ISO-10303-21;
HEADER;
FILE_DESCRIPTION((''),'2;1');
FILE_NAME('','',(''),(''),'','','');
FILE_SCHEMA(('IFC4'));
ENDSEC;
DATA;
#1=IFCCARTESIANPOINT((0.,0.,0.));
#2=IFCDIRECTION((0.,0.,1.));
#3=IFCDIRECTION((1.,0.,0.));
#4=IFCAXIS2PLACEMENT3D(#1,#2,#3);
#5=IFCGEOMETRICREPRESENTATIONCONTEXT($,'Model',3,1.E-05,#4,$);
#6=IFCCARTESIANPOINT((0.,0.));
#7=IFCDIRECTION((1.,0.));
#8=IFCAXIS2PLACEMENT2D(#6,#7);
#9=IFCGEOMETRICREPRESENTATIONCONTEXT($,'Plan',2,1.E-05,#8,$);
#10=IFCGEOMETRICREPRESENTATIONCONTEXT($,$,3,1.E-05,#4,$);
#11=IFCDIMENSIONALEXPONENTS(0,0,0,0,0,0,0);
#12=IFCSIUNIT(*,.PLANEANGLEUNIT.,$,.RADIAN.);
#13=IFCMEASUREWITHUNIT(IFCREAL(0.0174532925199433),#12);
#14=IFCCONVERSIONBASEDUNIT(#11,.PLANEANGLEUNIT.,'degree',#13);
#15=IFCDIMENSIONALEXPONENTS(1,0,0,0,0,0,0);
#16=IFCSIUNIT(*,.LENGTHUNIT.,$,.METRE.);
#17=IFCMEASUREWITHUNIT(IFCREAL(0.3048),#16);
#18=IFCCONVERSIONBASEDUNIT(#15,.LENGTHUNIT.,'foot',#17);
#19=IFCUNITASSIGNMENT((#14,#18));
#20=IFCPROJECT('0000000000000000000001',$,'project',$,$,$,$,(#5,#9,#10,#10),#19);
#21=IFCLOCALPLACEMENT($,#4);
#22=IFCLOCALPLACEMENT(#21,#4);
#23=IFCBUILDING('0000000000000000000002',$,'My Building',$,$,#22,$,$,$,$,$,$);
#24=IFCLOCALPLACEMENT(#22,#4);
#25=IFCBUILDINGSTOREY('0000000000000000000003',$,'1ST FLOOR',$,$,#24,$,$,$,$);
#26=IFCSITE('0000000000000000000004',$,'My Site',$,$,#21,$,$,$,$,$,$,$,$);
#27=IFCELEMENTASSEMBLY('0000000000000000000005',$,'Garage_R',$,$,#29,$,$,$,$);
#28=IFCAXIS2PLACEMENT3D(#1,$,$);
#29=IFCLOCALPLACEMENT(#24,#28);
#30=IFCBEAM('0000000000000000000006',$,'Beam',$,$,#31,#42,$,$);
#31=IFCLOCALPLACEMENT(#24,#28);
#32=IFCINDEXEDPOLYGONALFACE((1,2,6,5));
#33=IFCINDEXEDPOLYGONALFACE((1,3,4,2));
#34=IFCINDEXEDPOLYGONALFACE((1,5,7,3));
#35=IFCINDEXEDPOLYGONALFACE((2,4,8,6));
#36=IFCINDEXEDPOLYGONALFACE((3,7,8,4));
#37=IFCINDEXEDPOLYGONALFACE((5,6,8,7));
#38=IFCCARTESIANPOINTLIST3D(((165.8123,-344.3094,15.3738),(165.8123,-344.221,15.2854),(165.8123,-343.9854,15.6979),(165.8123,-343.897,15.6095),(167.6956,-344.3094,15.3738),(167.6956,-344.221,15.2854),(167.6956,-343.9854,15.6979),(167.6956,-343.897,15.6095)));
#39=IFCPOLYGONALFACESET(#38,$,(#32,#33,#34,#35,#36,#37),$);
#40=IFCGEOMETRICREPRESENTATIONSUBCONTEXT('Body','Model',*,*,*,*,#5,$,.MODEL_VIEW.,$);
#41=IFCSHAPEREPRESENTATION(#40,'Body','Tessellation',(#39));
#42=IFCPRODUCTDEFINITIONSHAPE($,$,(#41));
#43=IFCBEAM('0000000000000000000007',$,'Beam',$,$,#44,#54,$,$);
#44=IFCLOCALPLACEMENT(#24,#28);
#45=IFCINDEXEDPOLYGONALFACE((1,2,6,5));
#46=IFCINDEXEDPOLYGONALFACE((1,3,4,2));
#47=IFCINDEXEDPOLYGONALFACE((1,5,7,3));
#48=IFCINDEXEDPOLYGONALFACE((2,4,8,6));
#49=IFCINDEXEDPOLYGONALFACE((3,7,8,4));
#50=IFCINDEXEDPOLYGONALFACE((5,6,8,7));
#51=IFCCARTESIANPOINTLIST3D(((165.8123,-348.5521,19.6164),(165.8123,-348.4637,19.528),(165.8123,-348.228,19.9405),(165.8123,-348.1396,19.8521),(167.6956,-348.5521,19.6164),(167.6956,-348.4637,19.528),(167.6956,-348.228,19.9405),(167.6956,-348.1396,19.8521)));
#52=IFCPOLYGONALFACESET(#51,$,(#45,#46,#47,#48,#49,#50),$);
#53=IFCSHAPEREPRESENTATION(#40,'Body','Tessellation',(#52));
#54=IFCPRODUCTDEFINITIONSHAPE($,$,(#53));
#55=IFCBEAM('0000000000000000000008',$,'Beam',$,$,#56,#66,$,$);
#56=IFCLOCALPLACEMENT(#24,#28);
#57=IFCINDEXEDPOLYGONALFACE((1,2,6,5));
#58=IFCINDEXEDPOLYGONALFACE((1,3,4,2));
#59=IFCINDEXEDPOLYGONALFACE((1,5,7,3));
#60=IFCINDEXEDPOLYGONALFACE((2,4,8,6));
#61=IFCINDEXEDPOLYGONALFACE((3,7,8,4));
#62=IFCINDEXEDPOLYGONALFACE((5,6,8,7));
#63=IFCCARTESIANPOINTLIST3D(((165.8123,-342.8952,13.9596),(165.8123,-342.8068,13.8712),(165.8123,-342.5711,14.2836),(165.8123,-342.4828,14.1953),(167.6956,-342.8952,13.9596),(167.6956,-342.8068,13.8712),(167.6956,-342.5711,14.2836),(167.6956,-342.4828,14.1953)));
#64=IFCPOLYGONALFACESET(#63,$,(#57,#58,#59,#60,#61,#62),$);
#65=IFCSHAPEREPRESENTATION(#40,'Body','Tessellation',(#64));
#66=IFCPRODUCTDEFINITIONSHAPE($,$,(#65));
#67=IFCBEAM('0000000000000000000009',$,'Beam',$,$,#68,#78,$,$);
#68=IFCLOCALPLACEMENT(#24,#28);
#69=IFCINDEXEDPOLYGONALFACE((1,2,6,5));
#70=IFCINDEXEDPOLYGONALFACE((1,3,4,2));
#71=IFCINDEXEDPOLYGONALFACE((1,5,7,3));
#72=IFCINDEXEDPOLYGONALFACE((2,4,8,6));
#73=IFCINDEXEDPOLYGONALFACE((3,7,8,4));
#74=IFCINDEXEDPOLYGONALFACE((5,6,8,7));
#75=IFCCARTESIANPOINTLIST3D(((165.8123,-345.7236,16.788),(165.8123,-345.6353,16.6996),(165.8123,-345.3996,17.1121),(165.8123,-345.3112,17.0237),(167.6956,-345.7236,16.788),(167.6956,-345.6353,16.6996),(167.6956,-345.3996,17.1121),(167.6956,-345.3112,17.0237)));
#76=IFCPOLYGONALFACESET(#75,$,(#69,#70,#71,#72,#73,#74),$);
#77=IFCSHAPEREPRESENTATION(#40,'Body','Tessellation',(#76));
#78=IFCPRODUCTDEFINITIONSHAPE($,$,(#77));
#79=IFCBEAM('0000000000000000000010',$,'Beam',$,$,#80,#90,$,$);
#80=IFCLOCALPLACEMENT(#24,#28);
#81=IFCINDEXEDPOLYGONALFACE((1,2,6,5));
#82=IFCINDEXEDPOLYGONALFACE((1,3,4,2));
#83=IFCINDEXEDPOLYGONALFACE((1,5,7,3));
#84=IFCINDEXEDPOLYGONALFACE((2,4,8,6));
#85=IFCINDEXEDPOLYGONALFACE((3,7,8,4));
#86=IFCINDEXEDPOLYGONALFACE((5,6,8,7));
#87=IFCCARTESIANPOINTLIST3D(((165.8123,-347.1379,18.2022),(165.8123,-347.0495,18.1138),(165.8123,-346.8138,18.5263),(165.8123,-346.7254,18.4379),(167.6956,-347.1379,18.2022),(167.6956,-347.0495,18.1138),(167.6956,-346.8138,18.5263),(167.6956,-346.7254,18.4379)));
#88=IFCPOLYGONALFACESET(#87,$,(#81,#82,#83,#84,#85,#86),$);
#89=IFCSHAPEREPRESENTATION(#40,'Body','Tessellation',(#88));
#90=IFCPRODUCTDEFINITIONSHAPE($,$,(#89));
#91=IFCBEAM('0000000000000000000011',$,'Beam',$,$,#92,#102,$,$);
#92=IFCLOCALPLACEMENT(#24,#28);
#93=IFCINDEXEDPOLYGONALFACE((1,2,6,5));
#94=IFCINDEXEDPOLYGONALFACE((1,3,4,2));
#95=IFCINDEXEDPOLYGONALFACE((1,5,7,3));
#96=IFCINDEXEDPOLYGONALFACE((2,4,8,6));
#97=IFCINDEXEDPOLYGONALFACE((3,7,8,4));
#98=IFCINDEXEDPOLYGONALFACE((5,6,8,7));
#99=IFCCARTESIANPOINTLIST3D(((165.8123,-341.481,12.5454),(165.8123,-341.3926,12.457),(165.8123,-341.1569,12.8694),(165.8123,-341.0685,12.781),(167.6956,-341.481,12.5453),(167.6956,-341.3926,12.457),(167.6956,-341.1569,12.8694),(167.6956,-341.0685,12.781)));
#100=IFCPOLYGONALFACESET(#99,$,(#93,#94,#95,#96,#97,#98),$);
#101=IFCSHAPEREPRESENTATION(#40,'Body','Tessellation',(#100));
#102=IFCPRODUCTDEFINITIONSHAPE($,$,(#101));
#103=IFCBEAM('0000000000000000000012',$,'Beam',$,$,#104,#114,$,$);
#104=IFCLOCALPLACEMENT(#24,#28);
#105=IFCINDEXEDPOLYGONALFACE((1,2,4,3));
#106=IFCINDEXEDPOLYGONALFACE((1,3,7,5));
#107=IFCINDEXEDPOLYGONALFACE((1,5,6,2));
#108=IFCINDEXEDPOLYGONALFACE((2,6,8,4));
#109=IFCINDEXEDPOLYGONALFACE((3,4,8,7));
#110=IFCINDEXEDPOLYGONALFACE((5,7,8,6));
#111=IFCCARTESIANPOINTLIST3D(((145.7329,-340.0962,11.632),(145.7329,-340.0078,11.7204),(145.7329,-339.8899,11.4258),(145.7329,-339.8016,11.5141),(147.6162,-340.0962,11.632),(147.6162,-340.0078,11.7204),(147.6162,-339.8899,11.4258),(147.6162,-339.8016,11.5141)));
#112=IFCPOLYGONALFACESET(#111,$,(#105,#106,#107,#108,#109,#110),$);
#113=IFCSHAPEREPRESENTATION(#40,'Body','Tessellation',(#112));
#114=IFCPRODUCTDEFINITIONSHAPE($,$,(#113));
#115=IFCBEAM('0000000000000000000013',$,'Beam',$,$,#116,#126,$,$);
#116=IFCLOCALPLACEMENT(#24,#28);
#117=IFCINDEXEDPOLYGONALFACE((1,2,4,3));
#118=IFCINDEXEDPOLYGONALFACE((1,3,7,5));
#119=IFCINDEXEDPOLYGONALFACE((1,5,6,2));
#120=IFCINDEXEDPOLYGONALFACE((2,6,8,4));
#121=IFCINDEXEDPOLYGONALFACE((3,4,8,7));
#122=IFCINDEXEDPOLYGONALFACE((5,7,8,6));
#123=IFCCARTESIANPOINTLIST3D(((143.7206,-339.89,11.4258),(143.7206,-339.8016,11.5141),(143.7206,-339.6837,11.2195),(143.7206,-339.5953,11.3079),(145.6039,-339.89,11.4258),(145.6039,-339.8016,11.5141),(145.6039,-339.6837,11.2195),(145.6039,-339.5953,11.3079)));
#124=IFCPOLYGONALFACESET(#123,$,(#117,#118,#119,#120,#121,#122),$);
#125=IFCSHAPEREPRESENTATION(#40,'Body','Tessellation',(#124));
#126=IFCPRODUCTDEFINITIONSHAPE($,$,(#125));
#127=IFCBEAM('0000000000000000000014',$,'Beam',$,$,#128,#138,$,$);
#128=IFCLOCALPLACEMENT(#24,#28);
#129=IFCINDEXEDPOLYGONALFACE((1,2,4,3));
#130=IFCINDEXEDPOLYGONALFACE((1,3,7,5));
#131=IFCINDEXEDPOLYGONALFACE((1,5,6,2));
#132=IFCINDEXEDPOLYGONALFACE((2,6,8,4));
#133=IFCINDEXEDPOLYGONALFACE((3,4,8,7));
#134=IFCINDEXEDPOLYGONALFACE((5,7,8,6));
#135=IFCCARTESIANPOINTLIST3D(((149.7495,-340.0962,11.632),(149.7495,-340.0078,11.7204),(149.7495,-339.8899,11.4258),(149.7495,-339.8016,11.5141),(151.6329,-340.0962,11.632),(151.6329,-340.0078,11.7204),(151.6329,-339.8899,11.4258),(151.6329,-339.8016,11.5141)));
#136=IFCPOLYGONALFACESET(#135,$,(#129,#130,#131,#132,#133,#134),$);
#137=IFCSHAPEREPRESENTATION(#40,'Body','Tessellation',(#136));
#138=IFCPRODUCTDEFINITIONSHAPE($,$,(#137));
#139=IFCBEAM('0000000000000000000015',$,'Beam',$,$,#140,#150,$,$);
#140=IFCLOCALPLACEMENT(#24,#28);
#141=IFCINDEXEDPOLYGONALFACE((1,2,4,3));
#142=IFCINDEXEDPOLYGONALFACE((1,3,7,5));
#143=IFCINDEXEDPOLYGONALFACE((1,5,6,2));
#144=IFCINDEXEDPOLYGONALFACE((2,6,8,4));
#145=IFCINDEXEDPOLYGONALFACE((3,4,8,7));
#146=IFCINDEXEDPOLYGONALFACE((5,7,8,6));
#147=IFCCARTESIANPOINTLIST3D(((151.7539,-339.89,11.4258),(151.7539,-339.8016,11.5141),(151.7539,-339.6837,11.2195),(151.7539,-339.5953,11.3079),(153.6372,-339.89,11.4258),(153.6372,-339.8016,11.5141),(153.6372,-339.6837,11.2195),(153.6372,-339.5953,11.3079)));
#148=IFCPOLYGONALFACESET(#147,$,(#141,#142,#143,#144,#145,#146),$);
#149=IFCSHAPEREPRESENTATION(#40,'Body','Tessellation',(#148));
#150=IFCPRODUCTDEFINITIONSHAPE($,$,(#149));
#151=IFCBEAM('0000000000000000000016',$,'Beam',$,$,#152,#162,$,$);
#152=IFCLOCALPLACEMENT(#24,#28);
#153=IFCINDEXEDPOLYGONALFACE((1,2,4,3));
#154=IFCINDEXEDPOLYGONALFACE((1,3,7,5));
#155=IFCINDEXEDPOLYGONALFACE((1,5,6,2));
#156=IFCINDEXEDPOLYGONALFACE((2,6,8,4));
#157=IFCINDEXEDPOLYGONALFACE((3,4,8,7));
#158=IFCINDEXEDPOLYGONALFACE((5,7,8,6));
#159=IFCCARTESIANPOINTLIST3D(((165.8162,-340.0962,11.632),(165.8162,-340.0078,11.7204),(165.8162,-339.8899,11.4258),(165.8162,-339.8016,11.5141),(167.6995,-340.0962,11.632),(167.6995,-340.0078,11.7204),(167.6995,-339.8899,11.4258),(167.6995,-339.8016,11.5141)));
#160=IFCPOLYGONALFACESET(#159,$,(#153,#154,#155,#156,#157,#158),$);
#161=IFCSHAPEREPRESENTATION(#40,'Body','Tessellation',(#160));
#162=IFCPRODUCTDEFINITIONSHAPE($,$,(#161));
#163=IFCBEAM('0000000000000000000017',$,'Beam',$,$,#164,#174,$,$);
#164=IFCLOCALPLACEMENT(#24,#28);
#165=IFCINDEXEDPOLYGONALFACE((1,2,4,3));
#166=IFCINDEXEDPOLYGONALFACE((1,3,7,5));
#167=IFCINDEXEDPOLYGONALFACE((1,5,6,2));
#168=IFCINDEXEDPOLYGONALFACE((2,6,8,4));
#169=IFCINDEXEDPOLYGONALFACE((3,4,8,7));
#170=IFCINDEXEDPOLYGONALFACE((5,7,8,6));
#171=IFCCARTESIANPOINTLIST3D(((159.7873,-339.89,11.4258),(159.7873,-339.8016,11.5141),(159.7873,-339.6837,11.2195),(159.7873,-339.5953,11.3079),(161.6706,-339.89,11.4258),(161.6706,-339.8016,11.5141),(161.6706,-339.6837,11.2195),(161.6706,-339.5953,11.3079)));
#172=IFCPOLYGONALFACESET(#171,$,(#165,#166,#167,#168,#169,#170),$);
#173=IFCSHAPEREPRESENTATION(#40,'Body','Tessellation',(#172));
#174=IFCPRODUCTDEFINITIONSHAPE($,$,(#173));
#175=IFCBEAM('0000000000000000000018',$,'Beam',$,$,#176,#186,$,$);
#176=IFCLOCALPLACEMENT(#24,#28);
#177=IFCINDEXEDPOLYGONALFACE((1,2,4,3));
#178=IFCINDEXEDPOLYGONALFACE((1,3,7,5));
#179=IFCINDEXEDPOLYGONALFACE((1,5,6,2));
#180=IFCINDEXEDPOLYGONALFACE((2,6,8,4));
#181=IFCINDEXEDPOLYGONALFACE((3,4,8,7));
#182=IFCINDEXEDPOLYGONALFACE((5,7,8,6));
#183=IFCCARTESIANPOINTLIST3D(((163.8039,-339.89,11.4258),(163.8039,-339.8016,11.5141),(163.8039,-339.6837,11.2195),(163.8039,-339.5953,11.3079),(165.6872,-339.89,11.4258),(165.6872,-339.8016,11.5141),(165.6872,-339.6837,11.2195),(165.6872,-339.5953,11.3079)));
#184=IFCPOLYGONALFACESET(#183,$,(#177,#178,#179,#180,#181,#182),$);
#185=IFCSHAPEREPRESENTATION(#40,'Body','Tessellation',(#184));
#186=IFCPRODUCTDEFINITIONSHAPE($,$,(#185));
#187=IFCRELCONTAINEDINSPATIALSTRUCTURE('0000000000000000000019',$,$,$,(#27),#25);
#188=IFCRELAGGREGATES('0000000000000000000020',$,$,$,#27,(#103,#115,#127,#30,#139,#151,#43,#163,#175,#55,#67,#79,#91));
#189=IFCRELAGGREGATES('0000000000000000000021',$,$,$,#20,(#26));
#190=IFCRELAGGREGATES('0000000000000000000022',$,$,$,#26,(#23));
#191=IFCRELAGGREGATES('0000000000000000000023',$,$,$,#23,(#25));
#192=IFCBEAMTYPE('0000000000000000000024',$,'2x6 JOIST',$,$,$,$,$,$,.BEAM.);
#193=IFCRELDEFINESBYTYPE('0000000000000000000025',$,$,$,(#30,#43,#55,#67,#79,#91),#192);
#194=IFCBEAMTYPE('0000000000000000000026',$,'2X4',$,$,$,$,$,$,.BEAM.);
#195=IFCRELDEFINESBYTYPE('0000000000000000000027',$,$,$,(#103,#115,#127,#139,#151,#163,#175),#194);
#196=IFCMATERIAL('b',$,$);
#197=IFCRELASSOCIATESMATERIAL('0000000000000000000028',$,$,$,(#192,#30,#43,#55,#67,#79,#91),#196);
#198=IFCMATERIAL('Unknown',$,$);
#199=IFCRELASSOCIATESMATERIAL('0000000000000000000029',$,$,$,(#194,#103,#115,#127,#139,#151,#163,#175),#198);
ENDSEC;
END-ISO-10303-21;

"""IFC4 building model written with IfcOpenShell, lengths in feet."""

from ifc_helpers import new_model, entity, si_unit, converted_unit, frame, origin_with_axes, origin_2d_with_axis, place, context, subcontext, project, spatial, rectangle, extrude, material, material_profile, profile_set, profile_usage, type_object, element, aggregate, save


model = new_model("IFC4")

# Units and contexts
model_context = context("Model", 3, precision=1e-05, world=origin_with_axes())
plan_context = context("Plan", 2, precision=1e-05, world=origin_2d_with_axis())
context_of_model = context(None, 3, precision=1e-05, world=origin_with_axes())
body_context = subcontext(model_context, "Body", "Model", "MODEL_VIEW")
ifc_project = project(units=[converted_unit("PLANEANGLEUNIT", "degree", entity("IfcReal", 0.0174532925199433), si_unit("PLANEANGLEUNIT", "RADIAN"), dimensions=[0, 0, 0, 0, 0, 0, 0]), converted_unit("LENGTHUNIT", "foot", entity("IfcReal", 0.3048), si_unit("LENGTHUNIT", "METRE"), dimensions=[1, 0, 0, 0, 0, 0, 0])], contexts=[model_context, plan_context, context_of_model, context_of_model])

# Site, building, storey
site_placement = place(None, origin_with_axes())
site = spatial("IfcSite", under=ifc_project, at=site_placement, Name="My Site")
building_placement = place(site_placement, origin_with_axes())
building = spatial("IfcBuilding", under=site, at=building_placement, Name="My Building")
storey_placement = place(building_placement, origin_with_axes())
storey = spatial("IfcBuildingStorey", under=building, at=storey_placement, Name="1ST FLOOR")

# Element assembly, beams
assembly_1_placement = place(storey_placement, origin_with_axes())
assembly_1 = element("IfcElementAssembly", 1, at=assembly_1_placement, inside=storey, Name="Garage_R")
ifc_material_1 = material(Name="b")
ifc_material_profile_1 = material_profile(ifc_material_1, rectangle(XDim=0.125, YDim=0.4583))
ifc_profile_set_1 = profile_set([ifc_material_profile_1])
ifc_profile_usage_1 = profile_usage(ifc_profile_set_1, cardinal=8)
beam_type_1 = type_object("IfcBeamType", Name="2x6 JOIST", PredefinedType="BEAM", material=ifc_profile_set_1)
beam_1_placement = place(assembly_1_placement, frame((165.8123, -343.9412, 15.6537), z_axis=(1.0, 0.0, 0.0), x_axis=(0.0, 0.707107, -0.707107)))
beam_1 = element("IfcBeam", 2, at=beam_1_placement, type_object=beam_type_1, material=ifc_profile_usage_1, Name="Beam", context=body_context, shape_type="SweptSolid", body=[
    extrude(rectangle(XDim=0.125, YDim=0.4583), frame((0.0, -0.2291, 0.0)), (0.0, 0.0, 1.0), 1.8833),
])
ifc_profile_usage_2 = profile_usage(ifc_profile_set_1, cardinal=8)
beam_2_placement = place(assembly_1_placement, frame((165.8123, -348.1838, 19.8963), z_axis=(1.0, 0.0, 0.0), x_axis=(0.0, 0.707107, -0.707107)))
beam_2 = element("IfcBeam", 3, at=beam_2_placement, type_object=beam_type_1, material=ifc_profile_usage_2, Name="Beam", context=body_context, shape_type="SweptSolid", body=[
    extrude(rectangle(XDim=0.125, YDim=0.4583), frame((0.0, -0.2291, 0.0)), (0.0, 0.0, 1.0), 1.8833),
])
ifc_profile_usage_3 = profile_usage(ifc_profile_set_1, cardinal=8)
beam_3_placement = place(assembly_1_placement, frame((165.8123, -342.5269, 14.2395), z_axis=(1.0, 0.0, 0.0), x_axis=(0.0, 0.707107, -0.707107)))
beam_3 = element("IfcBeam", 4, at=beam_3_placement, type_object=beam_type_1, material=ifc_profile_usage_3, Name="Beam", context=body_context, shape_type="SweptSolid", body=[
    extrude(rectangle(XDim=0.125, YDim=0.4583), frame((0.0, -0.2291, 0.0)), (0.0, 0.0, 1.0), 1.8833),
])
ifc_profile_usage_4 = profile_usage(ifc_profile_set_1, cardinal=8)
beam_4_placement = place(assembly_1_placement, frame((165.8123, -345.3554, 17.0679), z_axis=(1.0, 0.0, 0.0), x_axis=(0.0, 0.707107, -0.707107)))
beam_4 = element("IfcBeam", 5, at=beam_4_placement, type_object=beam_type_1, material=ifc_profile_usage_4, Name="Beam", context=body_context, shape_type="SweptSolid", body=[
    extrude(rectangle(XDim=0.125, YDim=0.4583), frame((0.0, -0.2291, 0.0)), (0.0, 0.0, 1.0), 1.8833),
])
ifc_profile_usage_5 = profile_usage(ifc_profile_set_1, cardinal=8)
beam_5_placement = place(assembly_1_placement, frame((165.8123, -346.7696, 18.4821), z_axis=(1.0, 0.0, 0.0), x_axis=(0.0, 0.707107, -0.707107)))
beam_5 = element("IfcBeam", 6, at=beam_5_placement, type_object=beam_type_1, material=ifc_profile_usage_5, Name="Beam", context=body_context, shape_type="SweptSolid", body=[
    extrude(rectangle(XDim=0.125, YDim=0.4583), frame((0.0, -0.2291, 0.0)), (0.0, 0.0, 1.0), 1.8833),
])
ifc_profile_usage_6 = profile_usage(ifc_profile_set_1, cardinal=8)
beam_6_placement = place(assembly_1_placement, frame((165.8123, -341.1127, 12.8252), z_axis=(1.0, 0.0, 0.0), x_axis=(0.0, 0.707107, -0.707107)))
beam_6 = element("IfcBeam", 7, at=beam_6_placement, type_object=beam_type_1, material=ifc_profile_usage_6, Name="Beam", context=body_context, shape_type="SweptSolid", body=[
    extrude(rectangle(XDim=0.125, YDim=0.4583), frame((0.0, -0.2291, 0.0)), (0.0, 0.0, 1.0), 1.8833),
])
ifc_material_2 = material(Name="Unknown")
ifc_material_profile_2 = material_profile(ifc_material_2, rectangle(XDim=0.125, YDim=0.2917))
ifc_profile_set_2 = profile_set([ifc_material_profile_2])
ifc_profile_usage_7 = profile_usage(ifc_profile_set_2, cardinal=5)
beam_type_2 = type_object("IfcBeamType", Name="2X4", PredefinedType="BEAM", material=ifc_profile_set_2)
beam_7_placement = place(assembly_1_placement, frame((145.7329, -339.9489, 11.5731), z_axis=(1.0, 0.0, 0.0), x_axis=(0.0, -0.707107, -0.707107)))
beam_7 = element("IfcBeam", 8, at=beam_7_placement, type_object=beam_type_2, material=ifc_profile_usage_7, Name="Beam", context=body_context, shape_type="SweptSolid", body=[
    extrude(rectangle(XDim=0.125, YDim=0.2917), origin_with_axes(), (0.0, 0.0, 1.0), 1.8833),
])
ifc_profile_usage_8 = profile_usage(ifc_profile_set_2, cardinal=5)
beam_8_placement = place(assembly_1_placement, frame((143.7206, -339.7426, 11.3668), z_axis=(1.0, 0.0, 0.0), x_axis=(0.0, -0.707107, -0.707107)))
beam_8 = element("IfcBeam", 9, at=beam_8_placement, type_object=beam_type_2, material=ifc_profile_usage_8, Name="Beam", context=body_context, shape_type="SweptSolid", body=[
    extrude(rectangle(XDim=0.125, YDim=0.2917), origin_with_axes(), (0.0, 0.0, 1.0), 1.8833),
])
ifc_profile_usage_9 = profile_usage(ifc_profile_set_2, cardinal=5)
beam_9_placement = place(assembly_1_placement, frame((149.7495, -339.9489, 11.5731), z_axis=(1.0, 0.0, 0.0), x_axis=(0.0, -0.707107, -0.707107)))
beam_9 = element("IfcBeam", 10, at=beam_9_placement, type_object=beam_type_2, material=ifc_profile_usage_9, Name="Beam", context=body_context, shape_type="SweptSolid", body=[
    extrude(rectangle(XDim=0.125, YDim=0.2917), origin_with_axes(), (0.0, 0.0, 1.0), 1.8833),
])
ifc_profile_usage_10 = profile_usage(ifc_profile_set_2, cardinal=5)
beam_10_placement = place(assembly_1_placement, frame((151.7539, -339.7426, 11.3668), z_axis=(1.0, 0.0, 0.0), x_axis=(0.0, -0.707107, -0.707107)))
beam_10 = element("IfcBeam", 11, at=beam_10_placement, type_object=beam_type_2, material=ifc_profile_usage_10, Name="Beam", context=body_context, shape_type="SweptSolid", body=[
    extrude(rectangle(XDim=0.125, YDim=0.2917), origin_with_axes(), (0.0, 0.0, 1.0), 1.8833),
])
ifc_profile_usage_11 = profile_usage(ifc_profile_set_2, cardinal=5)
beam_11_placement = place(assembly_1_placement, frame((165.8162, -339.9489, 11.5731), z_axis=(1.0, 0.0, 0.0), x_axis=(0.0, -0.707107, -0.707107)))
beam_11 = element("IfcBeam", 12, at=beam_11_placement, type_object=beam_type_2, material=ifc_profile_usage_11, Name="Beam", context=body_context, shape_type="SweptSolid", body=[
    extrude(rectangle(XDim=0.125, YDim=0.2917), origin_with_axes(), (0.0, 0.0, 1.0), 1.8833),
])
ifc_profile_usage_12 = profile_usage(ifc_profile_set_2, cardinal=5)
beam_12_placement = place(assembly_1_placement, frame((159.7873, -339.7426, 11.3668), z_axis=(1.0, 0.0, 0.0), x_axis=(0.0, -0.707107, -0.707107)))
beam_12 = element("IfcBeam", 13, at=beam_12_placement, type_object=beam_type_2, material=ifc_profile_usage_12, Name="Beam", context=body_context, shape_type="SweptSolid", body=[
    extrude(rectangle(XDim=0.125, YDim=0.2917), origin_with_axes(), (0.0, 0.0, 1.0), 1.8833),
])
ifc_profile_usage_13 = profile_usage(ifc_profile_set_2, cardinal=5)
beam_13_placement = place(assembly_1_placement, frame((163.8039, -339.7426, 11.3668), z_axis=(1.0, 0.0, 0.0), x_axis=(0.0, -0.707107, -0.707107)))
beam_13 = element("IfcBeam", 14, at=beam_13_placement, type_object=beam_type_2, material=ifc_profile_usage_13, Name="Beam", context=body_context, shape_type="SweptSolid", body=[
    extrude(rectangle(XDim=0.125, YDim=0.2917), origin_with_axes(), (0.0, 0.0, 1.0), 1.8833),
])

aggregate(assembly_1, [beam_7, beam_8, beam_9, beam_1, beam_10, beam_11, beam_2, beam_12, beam_13, beam_3, beam_4, beam_5, beam_6])

save(model, "model.ifc")
